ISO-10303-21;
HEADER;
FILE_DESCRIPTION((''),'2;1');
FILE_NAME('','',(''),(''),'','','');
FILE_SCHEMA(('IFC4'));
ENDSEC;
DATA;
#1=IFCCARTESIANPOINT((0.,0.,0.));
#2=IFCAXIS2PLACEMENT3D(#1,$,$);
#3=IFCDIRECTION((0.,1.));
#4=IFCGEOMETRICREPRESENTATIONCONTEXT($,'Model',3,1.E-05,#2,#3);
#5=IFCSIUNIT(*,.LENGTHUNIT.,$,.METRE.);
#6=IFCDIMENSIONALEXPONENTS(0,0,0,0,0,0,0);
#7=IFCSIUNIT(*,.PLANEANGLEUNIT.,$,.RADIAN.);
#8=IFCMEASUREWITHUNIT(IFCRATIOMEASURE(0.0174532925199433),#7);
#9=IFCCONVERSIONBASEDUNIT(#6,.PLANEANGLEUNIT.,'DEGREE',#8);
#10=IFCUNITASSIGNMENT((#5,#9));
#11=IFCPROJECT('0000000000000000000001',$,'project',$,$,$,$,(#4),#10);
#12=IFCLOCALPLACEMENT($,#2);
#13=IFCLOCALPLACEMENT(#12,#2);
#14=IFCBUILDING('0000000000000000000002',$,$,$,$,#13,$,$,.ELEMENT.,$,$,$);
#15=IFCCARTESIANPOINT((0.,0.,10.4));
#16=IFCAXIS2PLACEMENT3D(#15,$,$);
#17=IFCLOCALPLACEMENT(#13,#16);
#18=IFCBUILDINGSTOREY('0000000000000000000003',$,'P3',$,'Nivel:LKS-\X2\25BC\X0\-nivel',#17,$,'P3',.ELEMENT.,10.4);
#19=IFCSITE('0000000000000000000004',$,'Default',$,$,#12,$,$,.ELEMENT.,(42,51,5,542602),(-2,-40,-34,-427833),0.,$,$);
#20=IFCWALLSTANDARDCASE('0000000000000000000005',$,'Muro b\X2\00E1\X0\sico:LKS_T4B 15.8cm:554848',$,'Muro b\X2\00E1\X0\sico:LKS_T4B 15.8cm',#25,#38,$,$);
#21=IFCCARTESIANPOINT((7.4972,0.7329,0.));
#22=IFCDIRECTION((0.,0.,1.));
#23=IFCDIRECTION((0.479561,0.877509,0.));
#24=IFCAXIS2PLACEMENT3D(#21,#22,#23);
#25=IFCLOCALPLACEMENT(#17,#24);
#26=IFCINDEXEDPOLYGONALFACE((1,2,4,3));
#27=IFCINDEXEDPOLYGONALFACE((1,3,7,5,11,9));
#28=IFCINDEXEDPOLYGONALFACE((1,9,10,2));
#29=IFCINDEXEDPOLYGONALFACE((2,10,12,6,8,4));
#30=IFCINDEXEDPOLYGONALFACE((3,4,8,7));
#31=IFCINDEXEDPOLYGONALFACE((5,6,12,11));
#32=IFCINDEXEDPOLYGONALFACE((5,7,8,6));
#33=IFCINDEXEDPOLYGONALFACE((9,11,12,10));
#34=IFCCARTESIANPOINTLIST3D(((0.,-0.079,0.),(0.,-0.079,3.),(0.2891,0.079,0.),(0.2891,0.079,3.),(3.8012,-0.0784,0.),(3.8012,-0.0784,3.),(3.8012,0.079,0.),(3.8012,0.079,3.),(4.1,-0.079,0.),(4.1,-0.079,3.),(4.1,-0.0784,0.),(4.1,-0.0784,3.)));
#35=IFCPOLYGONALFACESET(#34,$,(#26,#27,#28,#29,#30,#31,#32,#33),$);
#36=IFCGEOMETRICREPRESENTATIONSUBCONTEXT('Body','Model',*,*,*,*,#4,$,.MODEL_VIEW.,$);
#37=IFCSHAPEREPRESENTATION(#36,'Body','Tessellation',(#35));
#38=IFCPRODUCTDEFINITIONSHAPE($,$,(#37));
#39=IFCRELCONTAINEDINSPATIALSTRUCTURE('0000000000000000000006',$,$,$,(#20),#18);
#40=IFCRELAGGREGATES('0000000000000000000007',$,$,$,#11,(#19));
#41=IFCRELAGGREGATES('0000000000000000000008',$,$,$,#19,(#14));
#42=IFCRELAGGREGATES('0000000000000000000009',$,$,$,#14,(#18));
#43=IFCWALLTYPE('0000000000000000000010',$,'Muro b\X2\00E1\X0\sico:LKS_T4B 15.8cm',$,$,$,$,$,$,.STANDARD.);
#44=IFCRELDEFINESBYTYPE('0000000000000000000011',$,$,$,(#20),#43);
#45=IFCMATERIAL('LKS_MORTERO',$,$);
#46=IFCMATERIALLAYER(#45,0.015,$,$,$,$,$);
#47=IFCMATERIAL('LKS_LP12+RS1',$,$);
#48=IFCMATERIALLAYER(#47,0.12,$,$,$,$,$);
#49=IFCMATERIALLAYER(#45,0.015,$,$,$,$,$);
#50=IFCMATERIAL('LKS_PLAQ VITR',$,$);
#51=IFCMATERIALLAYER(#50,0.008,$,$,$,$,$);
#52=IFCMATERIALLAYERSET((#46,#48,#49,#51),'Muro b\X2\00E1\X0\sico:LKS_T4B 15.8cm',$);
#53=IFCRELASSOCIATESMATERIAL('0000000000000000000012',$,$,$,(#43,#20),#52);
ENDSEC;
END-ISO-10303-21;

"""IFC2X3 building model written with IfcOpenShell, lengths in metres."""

from ifc_helpers import new_model, entity, si_unit, converted_unit, direction, frame, origin, place, context, subcontext, project, spatial, polyline, outline, extrude, clip, bounded_halfspace, material, layer, layer_set, layer_usage, type_object, element, save


model = new_model("IFC2X3")

# Units and contexts
model_context = context("Model", 3, precision=1e-05, world=origin(), true_north=direction((0.0, 1.0)))
body_context = subcontext(model_context, "Body", "Model", "MODEL_VIEW")
ifc_project = project(units=[si_unit("LENGTHUNIT", "METRE"), converted_unit("PLANEANGLEUNIT", "DEGREE", entity("IfcRatioMeasure", 0.0174532925199433), si_unit("PLANEANGLEUNIT", "RADIAN"), dimensions=[0, 0, 0, 0, 0, 0, 0])], contexts=[model_context])

# Site, building, storey
site_placement = place(None, origin())
site = spatial("IfcSite", under=ifc_project, at=site_placement, Name="Default", CompositionType="ELEMENT", RefLatitude=(42, 51, 5, 542602), RefLongitude=(-2, -40, -34, -427833), RefElevation=0.0)
building_placement = place(site_placement, origin())
building = spatial("IfcBuilding", under=site, at=building_placement, CompositionType="ELEMENT")
storey_placement = place(building_placement, frame((0.0, 0.0, 10.4)))
storey = spatial("IfcBuildingStorey", under=building, at=storey_placement, Name="P3", ObjectType="Nivel:LKS-▼-nivel", LongName="P3", CompositionType="ELEMENT", Elevation=10.4)

# Wall
ifc_material_1 = material(Name="LKS_MORTERO")
ifc_layer_1 = layer(ifc_material_1, 0.015)
ifc_material_2 = material(Name="LKS_LP12+RS1")
ifc_layer_2 = layer(ifc_material_2, 0.12)
ifc_layer_3 = layer(ifc_material_1, 0.015)
ifc_material_3 = material(Name="LKS_PLAQ VITR")
ifc_layer_4 = layer(ifc_material_3, 0.008)
ifc_layer_set_1 = layer_set([ifc_layer_1, ifc_layer_2, ifc_layer_3, ifc_layer_4], Name="Muro básico:LKS_T4B 15.8cm")
ifc_layer_usage_1 = layer_usage(ifc_layer_set_1, "AXIS2", "POSITIVE", -0.079)
wall_type_1 = type_object("IfcWallType", Name="Muro básico:LKS_T4B 15.8cm", PredefinedType="STANDARD", material=ifc_layer_set_1)
wall_1_placement = place(storey_placement, frame((7.4972, 0.7329, 0.0), z_axis=(0.0, 0.0, 1.0), x_axis=(0.479561, 0.877509, 0.0)))
element("IfcWallStandardCase", 1, at=wall_1_placement, inside=storey, type_object=wall_type_1, material=ifc_layer_usage_1, Name="Muro básico:LKS_T4B 15.8cm:554848", ObjectType="Muro básico:LKS_T4B 15.8cm", context=body_context, shape_type="Clipping", body=[
    clip(clip(extrude(outline(polyline([(4.1, -0.079), (4.1, -0.0784), (3.8012, -0.0784), (3.8012, 0.079), (1.5591, 0.079), (1.4591, 0.079), (0.2891, 0.079), (0.0, -0.079), (4.1, -0.079)])), origin(), (0.0, 0.0, 1.0), 3.0), bounded_halfspace(frame((3.8012, -0.0784, 0.0), z_axis=(0.0, -1.0, 0.0), x_axis=(0.0, 0.0, -1.0)), True, frame((3.8012, -0.0784, 0.0), z_axis=(0.0, -1.0, 0.0), x_axis=(0.0, 0.0, -1.0)), polyline([(0.0, 0.0), (0.0, 0.2988), (-3.0, 0.2988), (-3.0, 0.0), (0.0, 0.0)]))), bounded_halfspace(frame((3.8012, -0.0784, 3.0), z_axis=(-1.0, 0.0, 0.0), x_axis=(0.0, 0.0, -1.0)), True, frame((3.8012, -0.0784, 3.0), z_axis=(-1.0, 0.0, 0.0), x_axis=(0.0, 0.0, -1.0)), polyline([(0.0, 0.0), (0.0, -0.048), (0.0, -0.1574), (3.0, -0.1574), (3.0, 0.0), (0.0, 0.0)]))),
])

save(model, "model.ifc")
